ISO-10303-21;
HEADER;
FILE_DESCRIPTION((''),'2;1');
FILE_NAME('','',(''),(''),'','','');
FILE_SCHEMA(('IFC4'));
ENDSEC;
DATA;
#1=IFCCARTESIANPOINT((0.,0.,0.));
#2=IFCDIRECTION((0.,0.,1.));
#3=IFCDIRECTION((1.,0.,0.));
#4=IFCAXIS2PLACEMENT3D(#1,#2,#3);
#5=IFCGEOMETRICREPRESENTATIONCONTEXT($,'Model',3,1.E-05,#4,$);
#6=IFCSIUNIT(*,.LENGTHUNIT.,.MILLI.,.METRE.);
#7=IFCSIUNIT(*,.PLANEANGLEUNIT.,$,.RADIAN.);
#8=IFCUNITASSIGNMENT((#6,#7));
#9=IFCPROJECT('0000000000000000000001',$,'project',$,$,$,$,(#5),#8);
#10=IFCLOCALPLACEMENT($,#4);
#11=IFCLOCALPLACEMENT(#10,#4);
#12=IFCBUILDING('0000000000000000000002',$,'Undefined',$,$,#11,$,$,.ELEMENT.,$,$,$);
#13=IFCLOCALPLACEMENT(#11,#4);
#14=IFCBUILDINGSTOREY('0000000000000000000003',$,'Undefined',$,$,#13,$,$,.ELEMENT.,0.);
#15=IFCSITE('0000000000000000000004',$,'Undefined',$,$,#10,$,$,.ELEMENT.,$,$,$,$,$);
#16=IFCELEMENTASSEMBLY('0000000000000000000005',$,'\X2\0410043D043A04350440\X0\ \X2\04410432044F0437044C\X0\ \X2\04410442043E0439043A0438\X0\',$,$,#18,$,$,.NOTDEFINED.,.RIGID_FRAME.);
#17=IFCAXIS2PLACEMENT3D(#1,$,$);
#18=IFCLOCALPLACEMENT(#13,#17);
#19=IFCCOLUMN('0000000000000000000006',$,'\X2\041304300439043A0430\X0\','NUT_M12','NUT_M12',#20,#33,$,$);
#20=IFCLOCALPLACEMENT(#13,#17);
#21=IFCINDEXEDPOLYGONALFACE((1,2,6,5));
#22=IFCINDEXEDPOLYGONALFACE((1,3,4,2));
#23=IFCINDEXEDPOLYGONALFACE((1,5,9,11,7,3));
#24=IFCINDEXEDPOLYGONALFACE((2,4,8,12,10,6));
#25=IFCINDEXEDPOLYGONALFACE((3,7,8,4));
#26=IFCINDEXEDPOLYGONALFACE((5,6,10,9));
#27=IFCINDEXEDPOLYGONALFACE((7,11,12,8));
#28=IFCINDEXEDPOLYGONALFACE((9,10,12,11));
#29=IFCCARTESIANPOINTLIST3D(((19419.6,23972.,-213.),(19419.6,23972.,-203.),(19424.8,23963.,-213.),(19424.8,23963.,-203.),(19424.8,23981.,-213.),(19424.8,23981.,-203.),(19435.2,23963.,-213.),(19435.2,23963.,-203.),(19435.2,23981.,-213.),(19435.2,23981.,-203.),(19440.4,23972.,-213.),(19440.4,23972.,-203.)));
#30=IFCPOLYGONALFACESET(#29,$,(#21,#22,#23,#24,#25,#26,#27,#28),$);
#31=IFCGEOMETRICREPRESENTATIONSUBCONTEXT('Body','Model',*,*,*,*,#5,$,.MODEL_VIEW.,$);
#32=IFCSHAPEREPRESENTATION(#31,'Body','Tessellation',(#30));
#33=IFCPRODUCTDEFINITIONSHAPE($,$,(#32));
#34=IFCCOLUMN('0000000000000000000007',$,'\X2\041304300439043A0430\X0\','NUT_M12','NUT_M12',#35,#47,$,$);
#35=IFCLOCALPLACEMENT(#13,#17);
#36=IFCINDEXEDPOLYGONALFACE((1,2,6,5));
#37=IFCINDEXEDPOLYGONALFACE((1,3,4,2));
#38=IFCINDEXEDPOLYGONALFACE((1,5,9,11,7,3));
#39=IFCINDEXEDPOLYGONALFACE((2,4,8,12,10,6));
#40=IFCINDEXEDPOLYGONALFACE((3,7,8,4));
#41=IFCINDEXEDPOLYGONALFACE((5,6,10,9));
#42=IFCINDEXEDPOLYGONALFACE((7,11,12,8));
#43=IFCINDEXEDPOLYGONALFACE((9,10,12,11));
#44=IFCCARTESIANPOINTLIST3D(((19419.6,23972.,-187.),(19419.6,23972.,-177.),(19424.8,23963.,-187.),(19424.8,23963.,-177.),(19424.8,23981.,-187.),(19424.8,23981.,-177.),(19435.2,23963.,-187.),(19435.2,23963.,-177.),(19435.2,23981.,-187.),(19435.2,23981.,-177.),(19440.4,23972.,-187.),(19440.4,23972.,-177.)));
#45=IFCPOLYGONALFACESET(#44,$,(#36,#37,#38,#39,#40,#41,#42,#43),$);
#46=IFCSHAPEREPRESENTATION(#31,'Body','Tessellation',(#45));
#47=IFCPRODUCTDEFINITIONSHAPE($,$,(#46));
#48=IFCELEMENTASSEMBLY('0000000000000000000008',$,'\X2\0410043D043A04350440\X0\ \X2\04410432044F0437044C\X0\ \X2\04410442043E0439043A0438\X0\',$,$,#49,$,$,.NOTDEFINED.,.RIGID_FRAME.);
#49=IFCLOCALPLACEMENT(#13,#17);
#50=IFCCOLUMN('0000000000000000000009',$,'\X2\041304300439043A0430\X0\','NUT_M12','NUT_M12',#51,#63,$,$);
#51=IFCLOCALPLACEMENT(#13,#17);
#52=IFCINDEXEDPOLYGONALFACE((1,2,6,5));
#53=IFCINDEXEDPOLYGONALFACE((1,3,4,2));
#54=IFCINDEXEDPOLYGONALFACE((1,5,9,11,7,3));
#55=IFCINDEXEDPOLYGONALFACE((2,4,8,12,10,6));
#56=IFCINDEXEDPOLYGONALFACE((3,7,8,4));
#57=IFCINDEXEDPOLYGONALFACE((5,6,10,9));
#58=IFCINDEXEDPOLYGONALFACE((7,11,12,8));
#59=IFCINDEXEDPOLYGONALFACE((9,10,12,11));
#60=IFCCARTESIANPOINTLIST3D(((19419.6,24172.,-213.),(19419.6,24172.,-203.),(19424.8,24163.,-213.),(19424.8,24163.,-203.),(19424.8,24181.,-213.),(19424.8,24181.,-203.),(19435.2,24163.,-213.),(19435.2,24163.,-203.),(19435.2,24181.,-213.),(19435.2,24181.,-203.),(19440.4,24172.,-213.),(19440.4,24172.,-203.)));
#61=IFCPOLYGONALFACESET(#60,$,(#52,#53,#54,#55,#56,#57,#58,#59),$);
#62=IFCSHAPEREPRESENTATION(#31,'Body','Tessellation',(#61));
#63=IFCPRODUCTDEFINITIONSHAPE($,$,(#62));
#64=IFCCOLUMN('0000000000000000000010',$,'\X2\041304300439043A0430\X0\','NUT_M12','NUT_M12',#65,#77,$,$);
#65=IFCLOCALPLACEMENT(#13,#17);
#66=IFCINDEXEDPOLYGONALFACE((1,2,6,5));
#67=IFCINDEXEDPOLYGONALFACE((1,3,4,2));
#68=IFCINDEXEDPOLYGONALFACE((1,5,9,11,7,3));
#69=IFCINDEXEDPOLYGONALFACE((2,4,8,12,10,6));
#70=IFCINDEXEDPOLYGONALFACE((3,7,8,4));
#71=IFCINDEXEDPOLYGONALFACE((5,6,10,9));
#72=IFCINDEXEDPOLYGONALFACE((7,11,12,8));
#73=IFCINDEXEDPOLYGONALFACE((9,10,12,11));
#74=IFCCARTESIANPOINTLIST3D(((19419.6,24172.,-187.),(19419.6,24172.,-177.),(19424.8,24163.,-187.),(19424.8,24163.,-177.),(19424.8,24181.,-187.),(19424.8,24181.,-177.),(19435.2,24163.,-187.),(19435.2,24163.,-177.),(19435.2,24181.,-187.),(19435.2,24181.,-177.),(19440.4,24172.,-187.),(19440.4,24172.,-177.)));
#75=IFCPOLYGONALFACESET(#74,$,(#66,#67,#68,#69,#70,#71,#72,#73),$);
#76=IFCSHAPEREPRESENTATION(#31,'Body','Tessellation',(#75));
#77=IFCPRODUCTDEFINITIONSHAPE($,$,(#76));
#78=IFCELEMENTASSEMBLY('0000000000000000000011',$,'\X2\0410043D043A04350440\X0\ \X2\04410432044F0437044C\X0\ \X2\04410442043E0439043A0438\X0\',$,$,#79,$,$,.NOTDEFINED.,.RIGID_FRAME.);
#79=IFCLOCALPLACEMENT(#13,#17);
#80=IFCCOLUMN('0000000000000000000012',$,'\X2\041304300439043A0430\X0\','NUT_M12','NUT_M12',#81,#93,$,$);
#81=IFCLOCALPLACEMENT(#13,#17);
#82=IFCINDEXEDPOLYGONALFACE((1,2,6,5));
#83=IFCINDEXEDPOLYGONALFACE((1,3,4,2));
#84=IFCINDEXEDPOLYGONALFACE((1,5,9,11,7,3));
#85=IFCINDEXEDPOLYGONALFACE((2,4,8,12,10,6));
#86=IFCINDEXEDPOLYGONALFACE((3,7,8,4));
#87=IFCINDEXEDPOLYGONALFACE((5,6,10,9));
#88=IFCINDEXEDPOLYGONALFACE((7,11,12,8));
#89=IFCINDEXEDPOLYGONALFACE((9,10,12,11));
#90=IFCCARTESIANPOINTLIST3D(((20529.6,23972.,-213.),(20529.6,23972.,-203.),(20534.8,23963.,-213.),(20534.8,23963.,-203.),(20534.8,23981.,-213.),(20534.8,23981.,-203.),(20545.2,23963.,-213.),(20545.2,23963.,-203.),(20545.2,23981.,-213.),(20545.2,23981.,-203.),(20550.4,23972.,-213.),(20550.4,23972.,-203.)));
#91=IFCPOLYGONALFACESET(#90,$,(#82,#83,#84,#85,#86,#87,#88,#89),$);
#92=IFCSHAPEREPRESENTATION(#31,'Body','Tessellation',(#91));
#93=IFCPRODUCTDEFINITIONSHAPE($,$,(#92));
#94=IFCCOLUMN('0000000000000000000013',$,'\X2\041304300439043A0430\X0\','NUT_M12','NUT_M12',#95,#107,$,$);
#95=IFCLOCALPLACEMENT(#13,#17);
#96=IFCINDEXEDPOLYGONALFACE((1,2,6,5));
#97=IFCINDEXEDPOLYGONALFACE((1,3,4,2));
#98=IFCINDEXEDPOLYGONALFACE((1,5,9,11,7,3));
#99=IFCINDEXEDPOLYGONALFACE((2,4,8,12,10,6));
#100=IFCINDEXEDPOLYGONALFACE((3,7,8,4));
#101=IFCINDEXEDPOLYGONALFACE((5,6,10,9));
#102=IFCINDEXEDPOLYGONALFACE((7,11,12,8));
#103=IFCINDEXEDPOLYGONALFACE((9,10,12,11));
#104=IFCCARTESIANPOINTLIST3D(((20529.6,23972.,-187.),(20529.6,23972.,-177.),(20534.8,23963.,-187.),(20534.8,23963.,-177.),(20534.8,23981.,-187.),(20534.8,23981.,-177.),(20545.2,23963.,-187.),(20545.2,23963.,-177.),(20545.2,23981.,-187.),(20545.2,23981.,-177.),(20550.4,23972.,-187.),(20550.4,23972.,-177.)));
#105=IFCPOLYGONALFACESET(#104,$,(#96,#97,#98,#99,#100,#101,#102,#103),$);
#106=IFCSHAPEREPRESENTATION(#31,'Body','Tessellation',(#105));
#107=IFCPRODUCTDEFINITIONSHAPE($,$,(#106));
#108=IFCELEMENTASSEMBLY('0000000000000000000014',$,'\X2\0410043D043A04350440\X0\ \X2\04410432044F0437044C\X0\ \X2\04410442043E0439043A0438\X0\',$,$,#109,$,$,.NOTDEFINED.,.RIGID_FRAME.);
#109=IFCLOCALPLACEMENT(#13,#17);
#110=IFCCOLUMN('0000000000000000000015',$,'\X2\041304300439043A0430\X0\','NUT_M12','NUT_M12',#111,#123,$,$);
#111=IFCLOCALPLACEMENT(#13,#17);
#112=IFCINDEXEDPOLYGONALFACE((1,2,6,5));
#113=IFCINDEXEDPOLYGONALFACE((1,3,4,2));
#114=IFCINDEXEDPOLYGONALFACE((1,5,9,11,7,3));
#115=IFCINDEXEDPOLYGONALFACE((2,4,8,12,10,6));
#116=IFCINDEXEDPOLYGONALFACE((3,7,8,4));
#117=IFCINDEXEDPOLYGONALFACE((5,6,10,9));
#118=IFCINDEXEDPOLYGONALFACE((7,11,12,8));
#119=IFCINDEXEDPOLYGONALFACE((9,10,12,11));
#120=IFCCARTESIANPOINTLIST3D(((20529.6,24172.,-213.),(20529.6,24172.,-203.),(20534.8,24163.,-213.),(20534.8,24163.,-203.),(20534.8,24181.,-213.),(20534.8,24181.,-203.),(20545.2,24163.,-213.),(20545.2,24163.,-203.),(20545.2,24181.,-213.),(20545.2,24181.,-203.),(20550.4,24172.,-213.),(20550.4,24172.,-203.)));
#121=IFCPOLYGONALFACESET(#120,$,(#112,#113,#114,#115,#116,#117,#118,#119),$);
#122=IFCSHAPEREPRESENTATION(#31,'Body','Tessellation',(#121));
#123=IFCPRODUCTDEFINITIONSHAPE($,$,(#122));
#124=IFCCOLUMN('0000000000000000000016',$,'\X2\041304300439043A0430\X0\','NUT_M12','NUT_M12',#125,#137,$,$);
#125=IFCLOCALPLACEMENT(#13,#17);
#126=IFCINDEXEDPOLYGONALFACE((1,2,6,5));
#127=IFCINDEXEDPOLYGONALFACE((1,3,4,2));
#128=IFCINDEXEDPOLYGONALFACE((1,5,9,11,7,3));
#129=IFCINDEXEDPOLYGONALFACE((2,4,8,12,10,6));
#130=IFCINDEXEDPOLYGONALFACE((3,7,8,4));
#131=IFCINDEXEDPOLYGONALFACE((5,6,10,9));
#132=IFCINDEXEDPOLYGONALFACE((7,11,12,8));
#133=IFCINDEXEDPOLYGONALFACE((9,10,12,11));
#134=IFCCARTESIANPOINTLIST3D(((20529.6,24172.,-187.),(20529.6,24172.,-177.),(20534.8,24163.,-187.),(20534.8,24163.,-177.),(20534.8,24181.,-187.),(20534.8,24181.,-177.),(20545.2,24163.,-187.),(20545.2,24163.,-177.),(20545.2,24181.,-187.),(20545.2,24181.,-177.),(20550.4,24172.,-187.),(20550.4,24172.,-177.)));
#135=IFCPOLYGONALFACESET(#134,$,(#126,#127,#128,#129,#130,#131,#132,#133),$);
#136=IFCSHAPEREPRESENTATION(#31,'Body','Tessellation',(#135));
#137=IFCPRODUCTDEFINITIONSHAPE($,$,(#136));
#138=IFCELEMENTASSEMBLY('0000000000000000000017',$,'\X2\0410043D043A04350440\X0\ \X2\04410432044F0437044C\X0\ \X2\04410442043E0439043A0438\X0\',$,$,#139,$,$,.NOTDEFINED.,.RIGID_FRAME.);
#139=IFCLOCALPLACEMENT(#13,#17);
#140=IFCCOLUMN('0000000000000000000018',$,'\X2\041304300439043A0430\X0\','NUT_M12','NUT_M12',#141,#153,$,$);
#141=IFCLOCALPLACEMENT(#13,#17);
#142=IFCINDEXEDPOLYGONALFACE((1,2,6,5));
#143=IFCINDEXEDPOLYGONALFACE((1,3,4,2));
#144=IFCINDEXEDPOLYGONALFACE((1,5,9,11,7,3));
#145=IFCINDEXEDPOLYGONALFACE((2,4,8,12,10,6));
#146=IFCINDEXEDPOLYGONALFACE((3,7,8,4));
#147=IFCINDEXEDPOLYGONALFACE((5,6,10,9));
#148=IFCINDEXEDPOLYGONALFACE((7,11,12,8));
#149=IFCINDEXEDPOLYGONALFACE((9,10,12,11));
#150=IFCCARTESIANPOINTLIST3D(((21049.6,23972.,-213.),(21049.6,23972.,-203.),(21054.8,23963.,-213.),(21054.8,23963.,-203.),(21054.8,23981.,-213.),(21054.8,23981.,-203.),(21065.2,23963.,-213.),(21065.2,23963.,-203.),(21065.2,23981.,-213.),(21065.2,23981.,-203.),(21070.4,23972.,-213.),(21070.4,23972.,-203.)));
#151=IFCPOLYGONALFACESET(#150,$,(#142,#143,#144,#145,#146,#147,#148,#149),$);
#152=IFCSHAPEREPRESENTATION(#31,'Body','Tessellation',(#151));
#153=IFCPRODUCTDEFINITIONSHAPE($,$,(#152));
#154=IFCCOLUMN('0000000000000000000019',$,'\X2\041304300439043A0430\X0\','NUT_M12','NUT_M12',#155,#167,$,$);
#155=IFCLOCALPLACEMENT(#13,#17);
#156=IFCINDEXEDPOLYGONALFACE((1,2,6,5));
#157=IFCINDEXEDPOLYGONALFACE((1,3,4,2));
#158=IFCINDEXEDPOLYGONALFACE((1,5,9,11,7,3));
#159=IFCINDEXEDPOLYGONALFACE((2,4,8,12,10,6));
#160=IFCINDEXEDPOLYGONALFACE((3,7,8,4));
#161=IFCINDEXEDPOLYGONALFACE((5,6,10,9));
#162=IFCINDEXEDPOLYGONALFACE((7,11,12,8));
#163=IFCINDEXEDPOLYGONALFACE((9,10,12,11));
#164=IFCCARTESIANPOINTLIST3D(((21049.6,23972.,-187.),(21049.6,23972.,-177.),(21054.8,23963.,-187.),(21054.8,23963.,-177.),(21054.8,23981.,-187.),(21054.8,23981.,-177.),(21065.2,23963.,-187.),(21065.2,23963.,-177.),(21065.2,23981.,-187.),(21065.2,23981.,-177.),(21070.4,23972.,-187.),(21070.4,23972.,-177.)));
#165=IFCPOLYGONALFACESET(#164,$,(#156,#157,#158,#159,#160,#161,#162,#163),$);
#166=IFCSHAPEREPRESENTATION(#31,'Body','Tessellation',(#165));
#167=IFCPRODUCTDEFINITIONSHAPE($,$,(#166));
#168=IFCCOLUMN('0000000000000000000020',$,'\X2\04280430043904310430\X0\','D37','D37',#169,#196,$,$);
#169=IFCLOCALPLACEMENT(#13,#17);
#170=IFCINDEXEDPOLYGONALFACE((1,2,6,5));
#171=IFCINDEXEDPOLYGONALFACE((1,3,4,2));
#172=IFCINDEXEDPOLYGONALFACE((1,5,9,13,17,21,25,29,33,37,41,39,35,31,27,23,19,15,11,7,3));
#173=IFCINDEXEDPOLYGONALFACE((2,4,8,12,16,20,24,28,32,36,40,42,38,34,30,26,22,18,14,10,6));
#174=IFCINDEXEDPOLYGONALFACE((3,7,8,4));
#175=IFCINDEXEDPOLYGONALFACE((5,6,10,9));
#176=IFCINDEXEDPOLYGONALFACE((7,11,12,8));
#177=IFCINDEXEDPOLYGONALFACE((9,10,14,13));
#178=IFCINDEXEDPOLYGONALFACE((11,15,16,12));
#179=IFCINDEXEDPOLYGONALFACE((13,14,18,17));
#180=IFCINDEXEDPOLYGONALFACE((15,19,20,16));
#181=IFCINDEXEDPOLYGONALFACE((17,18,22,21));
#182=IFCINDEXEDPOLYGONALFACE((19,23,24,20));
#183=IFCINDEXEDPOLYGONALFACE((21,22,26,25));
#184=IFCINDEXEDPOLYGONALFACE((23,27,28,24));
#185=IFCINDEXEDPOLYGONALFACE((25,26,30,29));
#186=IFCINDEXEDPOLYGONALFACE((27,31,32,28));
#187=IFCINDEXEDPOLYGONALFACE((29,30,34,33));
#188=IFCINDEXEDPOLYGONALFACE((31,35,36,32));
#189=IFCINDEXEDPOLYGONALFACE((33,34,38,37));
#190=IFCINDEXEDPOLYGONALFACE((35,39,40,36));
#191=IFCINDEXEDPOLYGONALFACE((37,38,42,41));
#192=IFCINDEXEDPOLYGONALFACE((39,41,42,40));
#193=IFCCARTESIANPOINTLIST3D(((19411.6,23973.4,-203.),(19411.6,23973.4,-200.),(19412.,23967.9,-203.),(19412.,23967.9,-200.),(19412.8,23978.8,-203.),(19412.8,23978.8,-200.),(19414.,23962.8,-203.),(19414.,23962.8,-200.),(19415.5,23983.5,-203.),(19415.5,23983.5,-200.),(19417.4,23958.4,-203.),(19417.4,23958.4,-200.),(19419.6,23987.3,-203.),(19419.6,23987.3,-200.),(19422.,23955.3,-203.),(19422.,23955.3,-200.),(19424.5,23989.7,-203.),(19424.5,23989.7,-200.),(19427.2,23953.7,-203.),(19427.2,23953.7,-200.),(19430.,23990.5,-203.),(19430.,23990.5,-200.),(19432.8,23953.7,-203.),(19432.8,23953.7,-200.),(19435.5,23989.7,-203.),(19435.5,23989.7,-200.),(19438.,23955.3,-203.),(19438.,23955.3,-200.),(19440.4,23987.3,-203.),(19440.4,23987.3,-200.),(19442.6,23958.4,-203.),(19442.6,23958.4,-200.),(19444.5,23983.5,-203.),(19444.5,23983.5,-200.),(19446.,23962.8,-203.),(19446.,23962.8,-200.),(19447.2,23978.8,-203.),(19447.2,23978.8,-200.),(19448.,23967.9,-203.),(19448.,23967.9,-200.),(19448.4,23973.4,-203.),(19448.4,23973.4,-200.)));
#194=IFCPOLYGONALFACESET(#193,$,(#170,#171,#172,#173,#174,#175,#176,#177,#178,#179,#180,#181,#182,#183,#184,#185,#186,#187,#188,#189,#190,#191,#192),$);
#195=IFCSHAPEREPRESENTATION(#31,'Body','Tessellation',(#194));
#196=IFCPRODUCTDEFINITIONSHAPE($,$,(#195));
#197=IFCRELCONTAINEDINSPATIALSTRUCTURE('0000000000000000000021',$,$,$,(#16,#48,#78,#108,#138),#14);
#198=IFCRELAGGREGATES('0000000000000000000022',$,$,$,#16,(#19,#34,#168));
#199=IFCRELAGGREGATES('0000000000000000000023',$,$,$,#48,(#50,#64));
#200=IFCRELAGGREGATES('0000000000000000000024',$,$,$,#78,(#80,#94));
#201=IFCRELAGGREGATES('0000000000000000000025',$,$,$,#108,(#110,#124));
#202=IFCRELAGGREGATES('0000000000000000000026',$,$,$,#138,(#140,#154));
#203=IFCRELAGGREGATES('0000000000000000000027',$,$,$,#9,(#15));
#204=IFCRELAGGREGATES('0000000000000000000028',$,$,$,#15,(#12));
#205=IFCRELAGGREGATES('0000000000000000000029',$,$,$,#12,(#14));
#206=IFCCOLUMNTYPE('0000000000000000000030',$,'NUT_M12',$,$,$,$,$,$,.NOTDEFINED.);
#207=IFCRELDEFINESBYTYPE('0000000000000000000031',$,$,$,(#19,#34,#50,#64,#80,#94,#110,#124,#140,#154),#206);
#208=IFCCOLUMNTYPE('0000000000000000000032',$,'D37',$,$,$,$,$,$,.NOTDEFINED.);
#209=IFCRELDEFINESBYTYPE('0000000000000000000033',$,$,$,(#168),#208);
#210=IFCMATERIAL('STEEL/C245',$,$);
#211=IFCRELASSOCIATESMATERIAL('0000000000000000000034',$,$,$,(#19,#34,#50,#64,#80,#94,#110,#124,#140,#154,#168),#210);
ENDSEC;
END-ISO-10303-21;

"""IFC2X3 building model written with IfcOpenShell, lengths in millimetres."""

from ifc_helpers import new_model, si_unit, frame, origin_with_axes, origin_2d_with_axis, place, context, subcontext, project, spatial, polyline, circle, outline, extrude, material, type_object, element, aggregate, save


model = new_model("IFC2X3")

# Units and contexts
model_context = context("Model", 3, precision=1e-05, world=origin_with_axes())
body_context = subcontext(model_context, "Body", "Model", "MODEL_VIEW")
ifc_project = project(units=[si_unit("LENGTHUNIT", "METRE", prefix="MILLI"), si_unit("PLANEANGLEUNIT", "RADIAN")], contexts=[model_context])

# Site, building, storey
site_placement = place(None, origin_with_axes())
site = spatial("IfcSite", under=ifc_project, at=site_placement, Name="Undefined", CompositionType="ELEMENT")
building_placement = place(site_placement, origin_with_axes())
building = spatial("IfcBuilding", under=site, at=building_placement, Name="Undefined", CompositionType="ELEMENT")
storey_placement = place(building_placement, origin_with_axes())
storey = spatial("IfcBuildingStorey", under=building, at=storey_placement, Name="Undefined", CompositionType="ELEMENT", Elevation=0.0)

# Element assemblies, columns
assembly_1_placement = place(storey_placement, origin_with_axes())
assembly_1 = element("IfcElementAssembly", 1, at=assembly_1_placement, inside=storey, Name="Анкер связь стойки", AssemblyPlace="NOTDEFINED", PredefinedType="RIGID_FRAME")
ifc_material_1 = material(Name="STEEL/C245")
column_type_1 = type_object("IfcColumnType", Name="NUT_M12", PredefinedType="NOTDEFINED")
column_1_placement = place(assembly_1_placement, frame((19430.0, 23972.0, -203.0), z_axis=(0.0, 0.0, -1.0), x_axis=(0.0, -1.0, 0.0)))
column_1 = element("IfcColumn", 2, at=column_1_placement, type_object=column_type_1, material=ifc_material_1, Name="Гайка", Description="NUT_M12", ObjectType="NUT_M12", context=body_context, shape_type="SweptSolid", body=[
    extrude(outline(polyline([(5.2, -9.0), (-5.2, -9.0), (-10.4, 0.0), (-5.2, 9.0), (5.2, 9.0), (10.4, 0.0), (5.2, -9.0)])), frame((0.0, 0.0, 10.0), z_axis=(0.0, 0.0, -1.0), x_axis=(0.0, 1.0, 0.0)), (0.0, 0.0, 1.0), 10.0),
])
column_2_placement = place(assembly_1_placement, frame((19430.0, 23972.0, -177.0), z_axis=(0.0, 0.0, -1.0), x_axis=(0.0, -1.0, 0.0)))
column_2 = element("IfcColumn", 3, at=column_2_placement, type_object=column_type_1, material=ifc_material_1, Name="Гайка", Description="NUT_M12", ObjectType="NUT_M12", context=body_context, shape_type="SweptSolid", body=[
    extrude(outline(polyline([(5.2, -9.0), (-5.2, -9.0), (-10.4, 0.0), (-5.2, 9.0), (5.2, 9.0), (10.4, 0.0), (5.2, -9.0)])), frame((0.0, 0.0, 10.0), z_axis=(0.0, 0.0, -1.0), x_axis=(0.0, 1.0, 0.0)), (0.0, 0.0, 1.0), 10.0),
])
assembly_2_placement = place(storey_placement, origin_with_axes())
assembly_2 = element("IfcElementAssembly", 4, at=assembly_2_placement, inside=storey, Name="Анкер связь стойки", AssemblyPlace="NOTDEFINED", PredefinedType="RIGID_FRAME")
column_3_placement = place(assembly_2_placement, frame((19430.0, 24172.0, -203.0), z_axis=(0.0, 0.0, -1.0), x_axis=(0.0, -1.0, 0.0)))
column_3 = element("IfcColumn", 5, at=column_3_placement, type_object=column_type_1, material=ifc_material_1, Name="Гайка", Description="NUT_M12", ObjectType="NUT_M12", context=body_context, shape_type="SweptSolid", body=[
    extrude(outline(polyline([(5.2, -9.0), (-5.2, -9.0), (-10.4, 0.0), (-5.2, 9.0), (5.2, 9.0), (10.4, 0.0), (5.2, -9.0)])), frame((0.0, 0.0, 10.0), z_axis=(0.0, 0.0, -1.0), x_axis=(0.0, 1.0, 0.0)), (0.0, 0.0, 1.0), 10.0),
])
column_4_placement = place(assembly_2_placement, frame((19430.0, 24172.0, -177.0), z_axis=(0.0, 0.0, -1.0), x_axis=(0.0, -1.0, 0.0)))
column_4 = element("IfcColumn", 6, at=column_4_placement, type_object=column_type_1, material=ifc_material_1, Name="Гайка", Description="NUT_M12", ObjectType="NUT_M12", context=body_context, shape_type="SweptSolid", body=[
    extrude(outline(polyline([(5.2, -9.0), (-5.2, -9.0), (-10.4, 0.0), (-5.2, 9.0), (5.2, 9.0), (10.4, 0.0), (5.2, -9.0)])), frame((0.0, 0.0, 10.0), z_axis=(0.0, 0.0, -1.0), x_axis=(0.0, 1.0, 0.0)), (0.0, 0.0, 1.0), 10.0),
])
assembly_3_placement = place(storey_placement, origin_with_axes())
assembly_3 = element("IfcElementAssembly", 7, at=assembly_3_placement, inside=storey, Name="Анкер связь стойки", AssemblyPlace="NOTDEFINED", PredefinedType="RIGID_FRAME")
column_5_placement = place(assembly_3_placement, frame((20540.0, 23972.0, -203.0), z_axis=(0.0, 0.0, -1.0), x_axis=(0.0, -1.0, 0.0)))
column_5 = element("IfcColumn", 8, at=column_5_placement, type_object=column_type_1, material=ifc_material_1, Name="Гайка", Description="NUT_M12", ObjectType="NUT_M12", context=body_context, shape_type="SweptSolid", body=[
    extrude(outline(polyline([(5.2, -9.0), (-5.2, -9.0), (-10.4, 0.0), (-5.2, 9.0), (5.2, 9.0), (10.4, 0.0), (5.2, -9.0)])), frame((0.0, 0.0, 10.0), z_axis=(0.0, 0.0, -1.0), x_axis=(0.0, 1.0, 0.0)), (0.0, 0.0, 1.0), 10.0),
])
column_6_placement = place(assembly_3_placement, frame((20540.0, 23972.0, -177.0), z_axis=(0.0, 0.0, -1.0), x_axis=(0.0, -1.0, 0.0)))
column_6 = element("IfcColumn", 9, at=column_6_placement, type_object=column_type_1, material=ifc_material_1, Name="Гайка", Description="NUT_M12", ObjectType="NUT_M12", context=body_context, shape_type="SweptSolid", body=[
    extrude(outline(polyline([(5.2, -9.0), (-5.2, -9.0), (-10.4, 0.0), (-5.2, 9.0), (5.2, 9.0), (10.4, 0.0), (5.2, -9.0)])), frame((0.0, 0.0, 10.0), z_axis=(0.0, 0.0, -1.0), x_axis=(0.0, 1.0, 0.0)), (0.0, 0.0, 1.0), 10.0),
])
assembly_4_placement = place(storey_placement, origin_with_axes())
assembly_4 = element("IfcElementAssembly", 10, at=assembly_4_placement, inside=storey, Name="Анкер связь стойки", AssemblyPlace="NOTDEFINED", PredefinedType="RIGID_FRAME")
column_7_placement = place(assembly_4_placement, frame((20540.0, 24172.0, -203.0), z_axis=(0.0, 0.0, -1.0), x_axis=(0.0, -1.0, 0.0)))
column_7 = element("IfcColumn", 11, at=column_7_placement, type_object=column_type_1, material=ifc_material_1, Name="Гайка", Description="NUT_M12", ObjectType="NUT_M12", context=body_context, shape_type="SweptSolid", body=[
    extrude(outline(polyline([(5.2, -9.0), (-5.2, -9.0), (-10.4, 0.0), (-5.2, 9.0), (5.2, 9.0), (10.4, 0.0), (5.2, -9.0)])), frame((0.0, 0.0, 10.0), z_axis=(0.0, 0.0, -1.0), x_axis=(0.0, 1.0, 0.0)), (0.0, 0.0, 1.0), 10.0),
])
column_8_placement = place(assembly_4_placement, frame((20540.0, 24172.0, -177.0), z_axis=(0.0, 0.0, -1.0), x_axis=(0.0, -1.0, 0.0)))
column_8 = element("IfcColumn", 12, at=column_8_placement, type_object=column_type_1, material=ifc_material_1, Name="Гайка", Description="NUT_M12", ObjectType="NUT_M12", context=body_context, shape_type="SweptSolid", body=[
    extrude(outline(polyline([(5.2, -9.0), (-5.2, -9.0), (-10.4, 0.0), (-5.2, 9.0), (5.2, 9.0), (10.4, 0.0), (5.2, -9.0)])), frame((0.0, 0.0, 10.0), z_axis=(0.0, 0.0, -1.0), x_axis=(0.0, 1.0, 0.0)), (0.0, 0.0, 1.0), 10.0),
])
assembly_5_placement = place(storey_placement, origin_with_axes())
assembly_5 = element("IfcElementAssembly", 13, at=assembly_5_placement, inside=storey, Name="Анкер связь стойки", AssemblyPlace="NOTDEFINED", PredefinedType="RIGID_FRAME")
column_9_placement = place(assembly_5_placement, frame((21060.0, 23972.0, -203.0), z_axis=(0.0, 0.0, -1.0), x_axis=(0.0, -1.0, 0.0)))
column_9 = element("IfcColumn", 14, at=column_9_placement, type_object=column_type_1, material=ifc_material_1, Name="Гайка", Description="NUT_M12", ObjectType="NUT_M12", context=body_context, shape_type="SweptSolid", body=[
    extrude(outline(polyline([(5.2, -9.0), (-5.2, -9.0), (-10.4, 0.0), (-5.2, 9.0), (5.2, 9.0), (10.4, 0.0), (5.2, -9.0)])), frame((0.0, 0.0, 10.0), z_axis=(0.0, 0.0, -1.0), x_axis=(0.0, 1.0, 0.0)), (0.0, 0.0, 1.0), 10.0),
])
column_10_placement = place(assembly_5_placement, frame((21060.0, 23972.0, -177.0), z_axis=(0.0, 0.0, -1.0), x_axis=(0.0, -1.0, 0.0)))
column_10 = element("IfcColumn", 15, at=column_10_placement, type_object=column_type_1, material=ifc_material_1, Name="Гайка", Description="NUT_M12", ObjectType="NUT_M12", context=body_context, shape_type="SweptSolid", body=[
    extrude(outline(polyline([(5.2, -9.0), (-5.2, -9.0), (-10.4, 0.0), (-5.2, 9.0), (5.2, 9.0), (10.4, 0.0), (5.2, -9.0)])), frame((0.0, 0.0, 10.0), z_axis=(0.0, 0.0, -1.0), x_axis=(0.0, 1.0, 0.0)), (0.0, 0.0, 1.0), 10.0),
])

# Column
column_type_2 = type_object("IfcColumnType", Name="D37", PredefinedType="NOTDEFINED")
column_11_placement = place(assembly_1_placement, frame((19430.0, 23972.0, -200.0), z_axis=(0.0, 0.0, -1.0), x_axis=(-1.0, 0.0, 0.0)))
column_11 = element("IfcColumn", 16, at=column_11_placement, type_object=column_type_2, material=ifc_material_1, Name="Шайба", Description="D37", ObjectType="D37", context=body_context, shape_type="SweptSolid", body=[
    extrude(circle(Radius=18.5, at=origin_2d_with_axis()), frame((0.0, 0.0, 3.0), z_axis=(0.0, 0.0, -1.0), x_axis=(0.0, 1.0, 0.0)), (0.0, 0.0, 1.0), 3.0),
])

aggregate(assembly_1, [column_1, column_2, column_11])
aggregate(assembly_2, [column_3, column_4])
aggregate(assembly_3, [column_5, column_6])
aggregate(assembly_4, [column_7, column_8])
aggregate(assembly_5, [column_9, column_10])

save(model, "model.ifc")
